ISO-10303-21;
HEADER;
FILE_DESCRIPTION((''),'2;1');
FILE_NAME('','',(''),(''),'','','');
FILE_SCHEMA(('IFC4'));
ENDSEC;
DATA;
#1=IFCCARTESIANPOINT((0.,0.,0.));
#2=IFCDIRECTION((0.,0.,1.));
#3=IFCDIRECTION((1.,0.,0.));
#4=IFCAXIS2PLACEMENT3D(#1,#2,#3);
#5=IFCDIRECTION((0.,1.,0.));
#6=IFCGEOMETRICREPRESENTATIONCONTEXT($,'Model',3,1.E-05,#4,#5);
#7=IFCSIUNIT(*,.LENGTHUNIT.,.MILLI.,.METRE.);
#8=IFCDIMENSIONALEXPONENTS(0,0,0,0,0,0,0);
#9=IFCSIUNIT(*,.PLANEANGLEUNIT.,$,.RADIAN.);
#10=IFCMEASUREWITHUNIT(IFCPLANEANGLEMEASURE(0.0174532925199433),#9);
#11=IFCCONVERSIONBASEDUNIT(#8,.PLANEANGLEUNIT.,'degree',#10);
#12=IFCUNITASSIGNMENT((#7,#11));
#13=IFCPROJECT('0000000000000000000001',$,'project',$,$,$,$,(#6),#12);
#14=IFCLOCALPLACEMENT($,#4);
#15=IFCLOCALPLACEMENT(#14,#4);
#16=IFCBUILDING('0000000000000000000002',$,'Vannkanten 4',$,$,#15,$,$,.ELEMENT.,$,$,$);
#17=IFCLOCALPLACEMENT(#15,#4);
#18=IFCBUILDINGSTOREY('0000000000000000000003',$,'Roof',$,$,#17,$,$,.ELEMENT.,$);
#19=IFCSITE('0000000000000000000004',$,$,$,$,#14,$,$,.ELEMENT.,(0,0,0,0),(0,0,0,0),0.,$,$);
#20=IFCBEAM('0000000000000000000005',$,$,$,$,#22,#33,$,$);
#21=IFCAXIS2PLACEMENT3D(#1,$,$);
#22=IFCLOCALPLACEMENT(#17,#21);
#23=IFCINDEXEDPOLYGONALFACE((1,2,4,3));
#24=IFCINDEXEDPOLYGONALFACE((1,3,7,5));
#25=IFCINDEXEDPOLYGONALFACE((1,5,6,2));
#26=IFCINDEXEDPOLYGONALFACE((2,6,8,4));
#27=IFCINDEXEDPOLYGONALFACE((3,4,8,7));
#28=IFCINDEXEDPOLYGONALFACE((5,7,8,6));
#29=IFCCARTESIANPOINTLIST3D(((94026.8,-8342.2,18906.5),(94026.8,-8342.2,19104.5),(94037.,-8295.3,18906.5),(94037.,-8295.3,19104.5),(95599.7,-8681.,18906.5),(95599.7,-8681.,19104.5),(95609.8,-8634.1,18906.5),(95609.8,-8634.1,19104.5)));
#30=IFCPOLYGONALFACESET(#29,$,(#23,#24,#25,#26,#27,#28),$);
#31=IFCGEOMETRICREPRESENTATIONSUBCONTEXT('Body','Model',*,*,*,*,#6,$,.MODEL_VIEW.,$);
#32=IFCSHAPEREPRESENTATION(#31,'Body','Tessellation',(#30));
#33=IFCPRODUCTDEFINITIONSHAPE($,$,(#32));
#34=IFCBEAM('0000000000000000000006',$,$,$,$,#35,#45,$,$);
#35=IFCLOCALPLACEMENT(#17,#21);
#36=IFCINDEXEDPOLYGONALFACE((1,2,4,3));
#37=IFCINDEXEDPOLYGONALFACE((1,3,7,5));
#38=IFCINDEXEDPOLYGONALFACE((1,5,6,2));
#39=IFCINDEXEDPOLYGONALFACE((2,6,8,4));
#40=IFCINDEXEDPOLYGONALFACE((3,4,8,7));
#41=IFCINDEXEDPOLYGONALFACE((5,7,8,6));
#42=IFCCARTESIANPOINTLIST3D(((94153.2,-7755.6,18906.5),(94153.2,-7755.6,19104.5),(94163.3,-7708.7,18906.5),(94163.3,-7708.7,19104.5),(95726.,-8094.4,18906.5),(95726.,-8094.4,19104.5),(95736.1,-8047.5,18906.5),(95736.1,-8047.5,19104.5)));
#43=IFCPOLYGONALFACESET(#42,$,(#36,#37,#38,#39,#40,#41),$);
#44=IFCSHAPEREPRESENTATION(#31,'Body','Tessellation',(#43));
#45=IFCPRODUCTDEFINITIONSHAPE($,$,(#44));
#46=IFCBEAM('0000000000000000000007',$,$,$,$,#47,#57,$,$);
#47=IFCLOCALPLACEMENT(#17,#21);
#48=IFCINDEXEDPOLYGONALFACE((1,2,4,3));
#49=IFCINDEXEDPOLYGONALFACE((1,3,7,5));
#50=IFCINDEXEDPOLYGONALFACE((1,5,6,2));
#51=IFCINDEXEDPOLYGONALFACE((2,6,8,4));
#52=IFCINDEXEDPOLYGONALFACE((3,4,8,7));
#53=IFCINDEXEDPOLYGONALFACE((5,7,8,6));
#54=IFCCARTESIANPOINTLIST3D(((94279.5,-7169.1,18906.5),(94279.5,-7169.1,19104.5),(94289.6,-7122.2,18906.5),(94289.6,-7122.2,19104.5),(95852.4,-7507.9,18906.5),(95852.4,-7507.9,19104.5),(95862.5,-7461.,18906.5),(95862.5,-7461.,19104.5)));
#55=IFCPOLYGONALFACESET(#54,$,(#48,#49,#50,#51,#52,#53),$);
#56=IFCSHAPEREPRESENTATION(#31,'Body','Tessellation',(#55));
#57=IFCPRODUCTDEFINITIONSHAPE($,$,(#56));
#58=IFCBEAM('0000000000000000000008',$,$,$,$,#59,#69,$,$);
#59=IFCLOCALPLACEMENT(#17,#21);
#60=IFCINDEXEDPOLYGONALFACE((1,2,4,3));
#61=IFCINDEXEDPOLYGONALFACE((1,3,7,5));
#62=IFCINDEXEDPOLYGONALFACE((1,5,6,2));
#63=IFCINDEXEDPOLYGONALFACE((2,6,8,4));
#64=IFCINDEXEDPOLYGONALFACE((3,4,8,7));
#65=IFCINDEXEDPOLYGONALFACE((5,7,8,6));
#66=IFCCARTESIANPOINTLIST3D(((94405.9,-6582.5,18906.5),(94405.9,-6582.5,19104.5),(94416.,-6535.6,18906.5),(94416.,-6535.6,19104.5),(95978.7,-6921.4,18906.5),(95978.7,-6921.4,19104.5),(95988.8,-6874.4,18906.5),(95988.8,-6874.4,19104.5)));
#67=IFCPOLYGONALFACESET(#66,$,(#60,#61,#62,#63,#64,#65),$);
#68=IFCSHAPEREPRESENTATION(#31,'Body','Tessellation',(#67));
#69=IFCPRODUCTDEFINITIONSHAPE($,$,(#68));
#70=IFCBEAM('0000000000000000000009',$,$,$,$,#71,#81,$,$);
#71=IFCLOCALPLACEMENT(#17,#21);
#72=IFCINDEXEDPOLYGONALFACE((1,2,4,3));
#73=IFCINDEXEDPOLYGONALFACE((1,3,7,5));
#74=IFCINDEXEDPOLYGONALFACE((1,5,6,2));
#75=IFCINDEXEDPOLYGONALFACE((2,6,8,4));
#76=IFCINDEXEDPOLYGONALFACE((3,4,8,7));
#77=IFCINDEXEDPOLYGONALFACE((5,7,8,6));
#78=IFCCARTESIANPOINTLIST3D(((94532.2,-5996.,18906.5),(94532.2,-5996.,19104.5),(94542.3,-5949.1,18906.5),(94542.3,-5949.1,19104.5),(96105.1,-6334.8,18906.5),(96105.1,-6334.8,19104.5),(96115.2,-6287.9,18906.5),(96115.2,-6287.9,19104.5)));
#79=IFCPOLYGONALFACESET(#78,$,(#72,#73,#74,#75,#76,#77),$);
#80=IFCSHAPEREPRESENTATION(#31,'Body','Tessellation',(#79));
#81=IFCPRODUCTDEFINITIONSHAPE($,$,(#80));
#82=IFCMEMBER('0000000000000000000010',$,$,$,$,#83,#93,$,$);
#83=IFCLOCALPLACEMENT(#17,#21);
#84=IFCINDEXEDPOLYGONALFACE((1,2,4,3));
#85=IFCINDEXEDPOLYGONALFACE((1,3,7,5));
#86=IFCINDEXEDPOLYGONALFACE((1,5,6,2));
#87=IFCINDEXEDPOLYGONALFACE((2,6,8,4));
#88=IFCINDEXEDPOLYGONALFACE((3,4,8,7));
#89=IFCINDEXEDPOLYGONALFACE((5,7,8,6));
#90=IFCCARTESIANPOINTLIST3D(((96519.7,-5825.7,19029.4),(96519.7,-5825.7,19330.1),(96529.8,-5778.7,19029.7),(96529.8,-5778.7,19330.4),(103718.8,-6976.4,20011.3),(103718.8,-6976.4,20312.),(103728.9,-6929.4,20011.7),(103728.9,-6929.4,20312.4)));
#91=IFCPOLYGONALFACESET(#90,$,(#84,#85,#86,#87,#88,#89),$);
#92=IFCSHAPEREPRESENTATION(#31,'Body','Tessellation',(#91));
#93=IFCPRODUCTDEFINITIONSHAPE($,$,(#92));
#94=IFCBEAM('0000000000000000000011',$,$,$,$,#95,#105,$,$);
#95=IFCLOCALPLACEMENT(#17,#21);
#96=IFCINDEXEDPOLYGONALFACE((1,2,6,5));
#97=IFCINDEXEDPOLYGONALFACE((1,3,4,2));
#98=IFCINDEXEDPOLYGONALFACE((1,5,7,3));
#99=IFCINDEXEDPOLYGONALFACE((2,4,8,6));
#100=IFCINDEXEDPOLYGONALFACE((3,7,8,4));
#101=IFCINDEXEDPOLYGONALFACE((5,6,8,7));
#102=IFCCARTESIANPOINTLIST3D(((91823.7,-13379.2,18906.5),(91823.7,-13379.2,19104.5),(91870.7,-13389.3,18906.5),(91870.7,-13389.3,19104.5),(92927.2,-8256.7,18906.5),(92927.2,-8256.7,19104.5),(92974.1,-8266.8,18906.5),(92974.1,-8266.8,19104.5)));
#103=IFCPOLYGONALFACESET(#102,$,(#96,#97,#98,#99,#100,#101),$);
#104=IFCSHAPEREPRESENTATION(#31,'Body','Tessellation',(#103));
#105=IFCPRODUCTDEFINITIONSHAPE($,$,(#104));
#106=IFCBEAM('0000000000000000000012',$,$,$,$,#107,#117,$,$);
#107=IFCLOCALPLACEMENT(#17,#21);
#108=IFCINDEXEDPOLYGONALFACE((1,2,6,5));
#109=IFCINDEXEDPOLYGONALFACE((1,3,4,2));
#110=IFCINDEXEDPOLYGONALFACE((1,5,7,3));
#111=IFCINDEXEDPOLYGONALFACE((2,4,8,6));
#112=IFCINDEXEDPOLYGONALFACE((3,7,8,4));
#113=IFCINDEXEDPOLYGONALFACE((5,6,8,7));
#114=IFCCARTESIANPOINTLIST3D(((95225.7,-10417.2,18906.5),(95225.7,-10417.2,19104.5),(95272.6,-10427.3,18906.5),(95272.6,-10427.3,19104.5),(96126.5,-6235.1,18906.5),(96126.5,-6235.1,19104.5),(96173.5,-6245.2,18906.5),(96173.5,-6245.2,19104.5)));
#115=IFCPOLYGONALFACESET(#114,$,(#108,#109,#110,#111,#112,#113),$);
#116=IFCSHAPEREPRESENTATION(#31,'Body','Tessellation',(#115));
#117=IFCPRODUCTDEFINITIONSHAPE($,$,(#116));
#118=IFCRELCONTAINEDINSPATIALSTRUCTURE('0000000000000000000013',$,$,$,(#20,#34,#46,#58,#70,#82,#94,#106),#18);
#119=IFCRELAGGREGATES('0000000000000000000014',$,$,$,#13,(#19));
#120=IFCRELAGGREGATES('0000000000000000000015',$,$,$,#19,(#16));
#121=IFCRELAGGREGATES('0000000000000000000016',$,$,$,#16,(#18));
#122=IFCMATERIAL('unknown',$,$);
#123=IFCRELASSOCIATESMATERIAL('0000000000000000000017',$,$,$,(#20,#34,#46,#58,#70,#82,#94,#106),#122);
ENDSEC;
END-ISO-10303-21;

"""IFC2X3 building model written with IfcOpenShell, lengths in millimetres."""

from ifc_helpers import new_model, entity, si_unit, converted_unit, direction, frame, origin_with_axes, place, context, subcontext, project, spatial, polyline, segment, composite_curve, outline, extrude, clip, halfspace, material, element, save


model = new_model("IFC2X3")

# Units and contexts
model_context = context("Model", 3, precision=1e-05, world=origin_with_axes(), true_north=direction((0.0, 1.0, 0.0)))
body_context = subcontext(model_context, "Body", "Model", "MODEL_VIEW")
ifc_project = project(units=[si_unit("LENGTHUNIT", "METRE", prefix="MILLI"), converted_unit("PLANEANGLEUNIT", "degree", entity("IfcPlaneAngleMeasure", 0.0174532925199433), si_unit("PLANEANGLEUNIT", "RADIAN"), dimensions=[0, 0, 0, 0, 0, 0, 0])], contexts=[model_context])

# Site, building, storey
site_placement = place(None, origin_with_axes())
site = spatial("IfcSite", under=ifc_project, at=site_placement, CompositionType="ELEMENT", RefLatitude=(0, 0, 0, 0), RefLongitude=(0, 0, 0, 0), RefElevation=0.0)
building_placement = place(site_placement, origin_with_axes())
building = spatial("IfcBuilding", under=site, at=building_placement, Name="Vannkanten 4", CompositionType="ELEMENT")
storey_placement = place(building_placement, origin_with_axes())
storey = spatial("IfcBuildingStorey", under=building, at=storey_placement, Name="Roof", CompositionType="ELEMENT")

# Shared definitions
ifc_material = material(Name="unknown")

# Beams
beam_1_placement = place(storey_placement, frame((95604.7, -8657.5, 19005.5), z_axis=(-0.977576, 0.210582, 0.0), x_axis=(-0.210582, -0.977576, 0.0)))
element("IfcBeam", 1, at=beam_1_placement, inside=storey, material=ifc_material, context=body_context, shape_type="SweptSolid", body=[
    extrude(outline(composite_curve([segment(polyline([(-24.0, -99.0), (-24.0, 99.0), (24.0, 99.0), (24.0, -99.0), (-24.0, -99.0)]), True, "CONTINUOUS")], self_intersect=False)), frame((0.0, 0.0, 0.0), z_axis=(0.0, 0.0, 1.0), x_axis=(1.0, 0.0, 0.0)), (0.0, 0.0, 1.0), 1608.9),
])
beam_2_placement = place(storey_placement, frame((95731.1, -8071.0, 19005.5), z_axis=(-0.977576, 0.210582, 0.0), x_axis=(-0.210582, -0.977576, 0.0)))
element("IfcBeam", 2, at=beam_2_placement, inside=storey, material=ifc_material, context=body_context, shape_type="SweptSolid", body=[
    extrude(outline(composite_curve([segment(polyline([(-24.0, -99.0), (-24.0, 99.0), (24.0, 99.0), (24.0, -99.0), (-24.0, -99.0)]), True, "CONTINUOUS")], self_intersect=False)), frame((0.0, 0.0, 0.0), z_axis=(0.0, 0.0, 1.0), x_axis=(1.0, 0.0, 0.0)), (0.0, 0.0, 1.0), 1608.9),
])
beam_3_placement = place(storey_placement, frame((95857.4, -7484.4, 19005.5), z_axis=(-0.977576, 0.210582, 0.0), x_axis=(-0.210582, -0.977576, 0.0)))
element("IfcBeam", 3, at=beam_3_placement, inside=storey, material=ifc_material, context=body_context, shape_type="SweptSolid", body=[
    extrude(outline(composite_curve([segment(polyline([(-24.0, -99.0), (-24.0, 99.0), (24.0, 99.0), (24.0, -99.0), (-24.0, -99.0)]), True, "CONTINUOUS")], self_intersect=False)), frame((0.0, 0.0, 0.0), z_axis=(0.0, 0.0, 1.0), x_axis=(1.0, 0.0, 0.0)), (0.0, 0.0, 1.0), 1608.9),
])
beam_4_placement = place(storey_placement, frame((95983.8, -6897.9, 19005.5), z_axis=(-0.977576, 0.210582, 0.0), x_axis=(-0.210582, -0.977576, 0.0)))
element("IfcBeam", 4, at=beam_4_placement, inside=storey, material=ifc_material, context=body_context, shape_type="SweptSolid", body=[
    extrude(outline(composite_curve([segment(polyline([(-24.0, -99.0), (-24.0, 99.0), (24.0, 99.0), (24.0, -99.0), (-24.0, -99.0)]), True, "CONTINUOUS")], self_intersect=False)), frame((0.0, 0.0, 0.0), z_axis=(0.0, 0.0, 1.0), x_axis=(1.0, 0.0, 0.0)), (0.0, 0.0, 1.0), 1608.9),
])
beam_5_placement = place(storey_placement, frame((96110.1, -6311.3, 19005.5), z_axis=(-0.977576, 0.210582, 0.0), x_axis=(-0.210582, -0.977576, 0.0)))
element("IfcBeam", 5, at=beam_5_placement, inside=storey, material=ifc_material, context=body_context, shape_type="SweptSolid", body=[
    extrude(outline(composite_curve([segment(polyline([(-24.0, -99.0), (-24.0, 99.0), (24.0, 99.0), (24.0, -99.0), (-24.0, -99.0)]), True, "CONTINUOUS")], self_intersect=False)), frame((0.0, 0.0, 0.0), z_axis=(0.0, 0.0, 1.0), x_axis=(1.0, 0.0, 0.0)), (0.0, 0.0, 1.0), 1608.9),
])

# Member
member_1_placement = place(storey_placement, frame((96524.7, -5802.2, 19179.9), z_axis=(0.978629, -0.156419, 0.133486), x_axis=(0.157832, 0.987466, 0.0)))
element("IfcMember", 6, at=member_1_placement, inside=storey, material=ifc_material, context=body_context, shape_type="Clipping", body=[
    clip(clip(extrude(outline(composite_curve([segment(polyline([(-24.0, -149.0), (-24.0, 149.0), (24.0, 149.0), (24.0, -149.0), (-24.0, -149.0)]), True, "CONTINUOUS")], self_intersect=False)), frame((0.0, 0.0, -3720.9), z_axis=(0.0, 0.0, 1.0), x_axis=(1.0, 0.0, 0.0)), (0.0, 0.0, 1.0), 14798.1), halfspace(frame((-24.0, 149.0, 18.8), z_axis=(-0.053649, -0.133294, 0.989623), x_axis=(0.0, 0.991051, 0.133486)), True)), halfspace(frame((24.0, 149.0, 7377.7), z_axis=(0.053649, 0.133294, -0.989623), x_axis=(0.0, -0.991051, -0.133486)), True)),
])

# Beams
beam_6_placement = place(storey_placement, frame((92950.6, -8261.8, 19005.5), z_axis=(-0.210582, -0.977576, 0.0), x_axis=(0.977576, -0.210582, 0.0)))
element("IfcBeam", 7, at=beam_6_placement, inside=storey, material=ifc_material, context=body_context, shape_type="SweptSolid", body=[
    extrude(outline(composite_curve([segment(polyline([(-24.0, -99.0), (-24.0, 99.0), (24.0, 99.0), (24.0, -99.0), (-24.0, -99.0)]), True, "CONTINUOUS")], self_intersect=False)), frame((0.0, 0.0, 0.0), z_axis=(0.0, 0.0, 1.0), x_axis=(1.0, 0.0, 0.0)), (0.0, 0.0, 1.0), 5240.0),
])
beam_7_placement = place(storey_placement, frame((96150.0, -6240.2, 19005.5), z_axis=(-0.210582, -0.977576, 0.0), x_axis=(0.977576, -0.210582, 0.0)))
element("IfcBeam", 8, at=beam_7_placement, inside=storey, material=ifc_material, context=body_context, shape_type="SweptSolid", body=[
    extrude(outline(composite_curve([segment(polyline([(-24.0, -99.0), (-24.0, 99.0), (24.0, 99.0), (24.0, -99.0), (-24.0, -99.0)]), True, "CONTINUOUS")], self_intersect=False)), frame((0.0, 0.0, 0.0), z_axis=(0.0, 0.0, 1.0), x_axis=(1.0, 0.0, 0.0)), (0.0, 0.0, 1.0), 4278.0),
])

save(model, "model.ifc")
